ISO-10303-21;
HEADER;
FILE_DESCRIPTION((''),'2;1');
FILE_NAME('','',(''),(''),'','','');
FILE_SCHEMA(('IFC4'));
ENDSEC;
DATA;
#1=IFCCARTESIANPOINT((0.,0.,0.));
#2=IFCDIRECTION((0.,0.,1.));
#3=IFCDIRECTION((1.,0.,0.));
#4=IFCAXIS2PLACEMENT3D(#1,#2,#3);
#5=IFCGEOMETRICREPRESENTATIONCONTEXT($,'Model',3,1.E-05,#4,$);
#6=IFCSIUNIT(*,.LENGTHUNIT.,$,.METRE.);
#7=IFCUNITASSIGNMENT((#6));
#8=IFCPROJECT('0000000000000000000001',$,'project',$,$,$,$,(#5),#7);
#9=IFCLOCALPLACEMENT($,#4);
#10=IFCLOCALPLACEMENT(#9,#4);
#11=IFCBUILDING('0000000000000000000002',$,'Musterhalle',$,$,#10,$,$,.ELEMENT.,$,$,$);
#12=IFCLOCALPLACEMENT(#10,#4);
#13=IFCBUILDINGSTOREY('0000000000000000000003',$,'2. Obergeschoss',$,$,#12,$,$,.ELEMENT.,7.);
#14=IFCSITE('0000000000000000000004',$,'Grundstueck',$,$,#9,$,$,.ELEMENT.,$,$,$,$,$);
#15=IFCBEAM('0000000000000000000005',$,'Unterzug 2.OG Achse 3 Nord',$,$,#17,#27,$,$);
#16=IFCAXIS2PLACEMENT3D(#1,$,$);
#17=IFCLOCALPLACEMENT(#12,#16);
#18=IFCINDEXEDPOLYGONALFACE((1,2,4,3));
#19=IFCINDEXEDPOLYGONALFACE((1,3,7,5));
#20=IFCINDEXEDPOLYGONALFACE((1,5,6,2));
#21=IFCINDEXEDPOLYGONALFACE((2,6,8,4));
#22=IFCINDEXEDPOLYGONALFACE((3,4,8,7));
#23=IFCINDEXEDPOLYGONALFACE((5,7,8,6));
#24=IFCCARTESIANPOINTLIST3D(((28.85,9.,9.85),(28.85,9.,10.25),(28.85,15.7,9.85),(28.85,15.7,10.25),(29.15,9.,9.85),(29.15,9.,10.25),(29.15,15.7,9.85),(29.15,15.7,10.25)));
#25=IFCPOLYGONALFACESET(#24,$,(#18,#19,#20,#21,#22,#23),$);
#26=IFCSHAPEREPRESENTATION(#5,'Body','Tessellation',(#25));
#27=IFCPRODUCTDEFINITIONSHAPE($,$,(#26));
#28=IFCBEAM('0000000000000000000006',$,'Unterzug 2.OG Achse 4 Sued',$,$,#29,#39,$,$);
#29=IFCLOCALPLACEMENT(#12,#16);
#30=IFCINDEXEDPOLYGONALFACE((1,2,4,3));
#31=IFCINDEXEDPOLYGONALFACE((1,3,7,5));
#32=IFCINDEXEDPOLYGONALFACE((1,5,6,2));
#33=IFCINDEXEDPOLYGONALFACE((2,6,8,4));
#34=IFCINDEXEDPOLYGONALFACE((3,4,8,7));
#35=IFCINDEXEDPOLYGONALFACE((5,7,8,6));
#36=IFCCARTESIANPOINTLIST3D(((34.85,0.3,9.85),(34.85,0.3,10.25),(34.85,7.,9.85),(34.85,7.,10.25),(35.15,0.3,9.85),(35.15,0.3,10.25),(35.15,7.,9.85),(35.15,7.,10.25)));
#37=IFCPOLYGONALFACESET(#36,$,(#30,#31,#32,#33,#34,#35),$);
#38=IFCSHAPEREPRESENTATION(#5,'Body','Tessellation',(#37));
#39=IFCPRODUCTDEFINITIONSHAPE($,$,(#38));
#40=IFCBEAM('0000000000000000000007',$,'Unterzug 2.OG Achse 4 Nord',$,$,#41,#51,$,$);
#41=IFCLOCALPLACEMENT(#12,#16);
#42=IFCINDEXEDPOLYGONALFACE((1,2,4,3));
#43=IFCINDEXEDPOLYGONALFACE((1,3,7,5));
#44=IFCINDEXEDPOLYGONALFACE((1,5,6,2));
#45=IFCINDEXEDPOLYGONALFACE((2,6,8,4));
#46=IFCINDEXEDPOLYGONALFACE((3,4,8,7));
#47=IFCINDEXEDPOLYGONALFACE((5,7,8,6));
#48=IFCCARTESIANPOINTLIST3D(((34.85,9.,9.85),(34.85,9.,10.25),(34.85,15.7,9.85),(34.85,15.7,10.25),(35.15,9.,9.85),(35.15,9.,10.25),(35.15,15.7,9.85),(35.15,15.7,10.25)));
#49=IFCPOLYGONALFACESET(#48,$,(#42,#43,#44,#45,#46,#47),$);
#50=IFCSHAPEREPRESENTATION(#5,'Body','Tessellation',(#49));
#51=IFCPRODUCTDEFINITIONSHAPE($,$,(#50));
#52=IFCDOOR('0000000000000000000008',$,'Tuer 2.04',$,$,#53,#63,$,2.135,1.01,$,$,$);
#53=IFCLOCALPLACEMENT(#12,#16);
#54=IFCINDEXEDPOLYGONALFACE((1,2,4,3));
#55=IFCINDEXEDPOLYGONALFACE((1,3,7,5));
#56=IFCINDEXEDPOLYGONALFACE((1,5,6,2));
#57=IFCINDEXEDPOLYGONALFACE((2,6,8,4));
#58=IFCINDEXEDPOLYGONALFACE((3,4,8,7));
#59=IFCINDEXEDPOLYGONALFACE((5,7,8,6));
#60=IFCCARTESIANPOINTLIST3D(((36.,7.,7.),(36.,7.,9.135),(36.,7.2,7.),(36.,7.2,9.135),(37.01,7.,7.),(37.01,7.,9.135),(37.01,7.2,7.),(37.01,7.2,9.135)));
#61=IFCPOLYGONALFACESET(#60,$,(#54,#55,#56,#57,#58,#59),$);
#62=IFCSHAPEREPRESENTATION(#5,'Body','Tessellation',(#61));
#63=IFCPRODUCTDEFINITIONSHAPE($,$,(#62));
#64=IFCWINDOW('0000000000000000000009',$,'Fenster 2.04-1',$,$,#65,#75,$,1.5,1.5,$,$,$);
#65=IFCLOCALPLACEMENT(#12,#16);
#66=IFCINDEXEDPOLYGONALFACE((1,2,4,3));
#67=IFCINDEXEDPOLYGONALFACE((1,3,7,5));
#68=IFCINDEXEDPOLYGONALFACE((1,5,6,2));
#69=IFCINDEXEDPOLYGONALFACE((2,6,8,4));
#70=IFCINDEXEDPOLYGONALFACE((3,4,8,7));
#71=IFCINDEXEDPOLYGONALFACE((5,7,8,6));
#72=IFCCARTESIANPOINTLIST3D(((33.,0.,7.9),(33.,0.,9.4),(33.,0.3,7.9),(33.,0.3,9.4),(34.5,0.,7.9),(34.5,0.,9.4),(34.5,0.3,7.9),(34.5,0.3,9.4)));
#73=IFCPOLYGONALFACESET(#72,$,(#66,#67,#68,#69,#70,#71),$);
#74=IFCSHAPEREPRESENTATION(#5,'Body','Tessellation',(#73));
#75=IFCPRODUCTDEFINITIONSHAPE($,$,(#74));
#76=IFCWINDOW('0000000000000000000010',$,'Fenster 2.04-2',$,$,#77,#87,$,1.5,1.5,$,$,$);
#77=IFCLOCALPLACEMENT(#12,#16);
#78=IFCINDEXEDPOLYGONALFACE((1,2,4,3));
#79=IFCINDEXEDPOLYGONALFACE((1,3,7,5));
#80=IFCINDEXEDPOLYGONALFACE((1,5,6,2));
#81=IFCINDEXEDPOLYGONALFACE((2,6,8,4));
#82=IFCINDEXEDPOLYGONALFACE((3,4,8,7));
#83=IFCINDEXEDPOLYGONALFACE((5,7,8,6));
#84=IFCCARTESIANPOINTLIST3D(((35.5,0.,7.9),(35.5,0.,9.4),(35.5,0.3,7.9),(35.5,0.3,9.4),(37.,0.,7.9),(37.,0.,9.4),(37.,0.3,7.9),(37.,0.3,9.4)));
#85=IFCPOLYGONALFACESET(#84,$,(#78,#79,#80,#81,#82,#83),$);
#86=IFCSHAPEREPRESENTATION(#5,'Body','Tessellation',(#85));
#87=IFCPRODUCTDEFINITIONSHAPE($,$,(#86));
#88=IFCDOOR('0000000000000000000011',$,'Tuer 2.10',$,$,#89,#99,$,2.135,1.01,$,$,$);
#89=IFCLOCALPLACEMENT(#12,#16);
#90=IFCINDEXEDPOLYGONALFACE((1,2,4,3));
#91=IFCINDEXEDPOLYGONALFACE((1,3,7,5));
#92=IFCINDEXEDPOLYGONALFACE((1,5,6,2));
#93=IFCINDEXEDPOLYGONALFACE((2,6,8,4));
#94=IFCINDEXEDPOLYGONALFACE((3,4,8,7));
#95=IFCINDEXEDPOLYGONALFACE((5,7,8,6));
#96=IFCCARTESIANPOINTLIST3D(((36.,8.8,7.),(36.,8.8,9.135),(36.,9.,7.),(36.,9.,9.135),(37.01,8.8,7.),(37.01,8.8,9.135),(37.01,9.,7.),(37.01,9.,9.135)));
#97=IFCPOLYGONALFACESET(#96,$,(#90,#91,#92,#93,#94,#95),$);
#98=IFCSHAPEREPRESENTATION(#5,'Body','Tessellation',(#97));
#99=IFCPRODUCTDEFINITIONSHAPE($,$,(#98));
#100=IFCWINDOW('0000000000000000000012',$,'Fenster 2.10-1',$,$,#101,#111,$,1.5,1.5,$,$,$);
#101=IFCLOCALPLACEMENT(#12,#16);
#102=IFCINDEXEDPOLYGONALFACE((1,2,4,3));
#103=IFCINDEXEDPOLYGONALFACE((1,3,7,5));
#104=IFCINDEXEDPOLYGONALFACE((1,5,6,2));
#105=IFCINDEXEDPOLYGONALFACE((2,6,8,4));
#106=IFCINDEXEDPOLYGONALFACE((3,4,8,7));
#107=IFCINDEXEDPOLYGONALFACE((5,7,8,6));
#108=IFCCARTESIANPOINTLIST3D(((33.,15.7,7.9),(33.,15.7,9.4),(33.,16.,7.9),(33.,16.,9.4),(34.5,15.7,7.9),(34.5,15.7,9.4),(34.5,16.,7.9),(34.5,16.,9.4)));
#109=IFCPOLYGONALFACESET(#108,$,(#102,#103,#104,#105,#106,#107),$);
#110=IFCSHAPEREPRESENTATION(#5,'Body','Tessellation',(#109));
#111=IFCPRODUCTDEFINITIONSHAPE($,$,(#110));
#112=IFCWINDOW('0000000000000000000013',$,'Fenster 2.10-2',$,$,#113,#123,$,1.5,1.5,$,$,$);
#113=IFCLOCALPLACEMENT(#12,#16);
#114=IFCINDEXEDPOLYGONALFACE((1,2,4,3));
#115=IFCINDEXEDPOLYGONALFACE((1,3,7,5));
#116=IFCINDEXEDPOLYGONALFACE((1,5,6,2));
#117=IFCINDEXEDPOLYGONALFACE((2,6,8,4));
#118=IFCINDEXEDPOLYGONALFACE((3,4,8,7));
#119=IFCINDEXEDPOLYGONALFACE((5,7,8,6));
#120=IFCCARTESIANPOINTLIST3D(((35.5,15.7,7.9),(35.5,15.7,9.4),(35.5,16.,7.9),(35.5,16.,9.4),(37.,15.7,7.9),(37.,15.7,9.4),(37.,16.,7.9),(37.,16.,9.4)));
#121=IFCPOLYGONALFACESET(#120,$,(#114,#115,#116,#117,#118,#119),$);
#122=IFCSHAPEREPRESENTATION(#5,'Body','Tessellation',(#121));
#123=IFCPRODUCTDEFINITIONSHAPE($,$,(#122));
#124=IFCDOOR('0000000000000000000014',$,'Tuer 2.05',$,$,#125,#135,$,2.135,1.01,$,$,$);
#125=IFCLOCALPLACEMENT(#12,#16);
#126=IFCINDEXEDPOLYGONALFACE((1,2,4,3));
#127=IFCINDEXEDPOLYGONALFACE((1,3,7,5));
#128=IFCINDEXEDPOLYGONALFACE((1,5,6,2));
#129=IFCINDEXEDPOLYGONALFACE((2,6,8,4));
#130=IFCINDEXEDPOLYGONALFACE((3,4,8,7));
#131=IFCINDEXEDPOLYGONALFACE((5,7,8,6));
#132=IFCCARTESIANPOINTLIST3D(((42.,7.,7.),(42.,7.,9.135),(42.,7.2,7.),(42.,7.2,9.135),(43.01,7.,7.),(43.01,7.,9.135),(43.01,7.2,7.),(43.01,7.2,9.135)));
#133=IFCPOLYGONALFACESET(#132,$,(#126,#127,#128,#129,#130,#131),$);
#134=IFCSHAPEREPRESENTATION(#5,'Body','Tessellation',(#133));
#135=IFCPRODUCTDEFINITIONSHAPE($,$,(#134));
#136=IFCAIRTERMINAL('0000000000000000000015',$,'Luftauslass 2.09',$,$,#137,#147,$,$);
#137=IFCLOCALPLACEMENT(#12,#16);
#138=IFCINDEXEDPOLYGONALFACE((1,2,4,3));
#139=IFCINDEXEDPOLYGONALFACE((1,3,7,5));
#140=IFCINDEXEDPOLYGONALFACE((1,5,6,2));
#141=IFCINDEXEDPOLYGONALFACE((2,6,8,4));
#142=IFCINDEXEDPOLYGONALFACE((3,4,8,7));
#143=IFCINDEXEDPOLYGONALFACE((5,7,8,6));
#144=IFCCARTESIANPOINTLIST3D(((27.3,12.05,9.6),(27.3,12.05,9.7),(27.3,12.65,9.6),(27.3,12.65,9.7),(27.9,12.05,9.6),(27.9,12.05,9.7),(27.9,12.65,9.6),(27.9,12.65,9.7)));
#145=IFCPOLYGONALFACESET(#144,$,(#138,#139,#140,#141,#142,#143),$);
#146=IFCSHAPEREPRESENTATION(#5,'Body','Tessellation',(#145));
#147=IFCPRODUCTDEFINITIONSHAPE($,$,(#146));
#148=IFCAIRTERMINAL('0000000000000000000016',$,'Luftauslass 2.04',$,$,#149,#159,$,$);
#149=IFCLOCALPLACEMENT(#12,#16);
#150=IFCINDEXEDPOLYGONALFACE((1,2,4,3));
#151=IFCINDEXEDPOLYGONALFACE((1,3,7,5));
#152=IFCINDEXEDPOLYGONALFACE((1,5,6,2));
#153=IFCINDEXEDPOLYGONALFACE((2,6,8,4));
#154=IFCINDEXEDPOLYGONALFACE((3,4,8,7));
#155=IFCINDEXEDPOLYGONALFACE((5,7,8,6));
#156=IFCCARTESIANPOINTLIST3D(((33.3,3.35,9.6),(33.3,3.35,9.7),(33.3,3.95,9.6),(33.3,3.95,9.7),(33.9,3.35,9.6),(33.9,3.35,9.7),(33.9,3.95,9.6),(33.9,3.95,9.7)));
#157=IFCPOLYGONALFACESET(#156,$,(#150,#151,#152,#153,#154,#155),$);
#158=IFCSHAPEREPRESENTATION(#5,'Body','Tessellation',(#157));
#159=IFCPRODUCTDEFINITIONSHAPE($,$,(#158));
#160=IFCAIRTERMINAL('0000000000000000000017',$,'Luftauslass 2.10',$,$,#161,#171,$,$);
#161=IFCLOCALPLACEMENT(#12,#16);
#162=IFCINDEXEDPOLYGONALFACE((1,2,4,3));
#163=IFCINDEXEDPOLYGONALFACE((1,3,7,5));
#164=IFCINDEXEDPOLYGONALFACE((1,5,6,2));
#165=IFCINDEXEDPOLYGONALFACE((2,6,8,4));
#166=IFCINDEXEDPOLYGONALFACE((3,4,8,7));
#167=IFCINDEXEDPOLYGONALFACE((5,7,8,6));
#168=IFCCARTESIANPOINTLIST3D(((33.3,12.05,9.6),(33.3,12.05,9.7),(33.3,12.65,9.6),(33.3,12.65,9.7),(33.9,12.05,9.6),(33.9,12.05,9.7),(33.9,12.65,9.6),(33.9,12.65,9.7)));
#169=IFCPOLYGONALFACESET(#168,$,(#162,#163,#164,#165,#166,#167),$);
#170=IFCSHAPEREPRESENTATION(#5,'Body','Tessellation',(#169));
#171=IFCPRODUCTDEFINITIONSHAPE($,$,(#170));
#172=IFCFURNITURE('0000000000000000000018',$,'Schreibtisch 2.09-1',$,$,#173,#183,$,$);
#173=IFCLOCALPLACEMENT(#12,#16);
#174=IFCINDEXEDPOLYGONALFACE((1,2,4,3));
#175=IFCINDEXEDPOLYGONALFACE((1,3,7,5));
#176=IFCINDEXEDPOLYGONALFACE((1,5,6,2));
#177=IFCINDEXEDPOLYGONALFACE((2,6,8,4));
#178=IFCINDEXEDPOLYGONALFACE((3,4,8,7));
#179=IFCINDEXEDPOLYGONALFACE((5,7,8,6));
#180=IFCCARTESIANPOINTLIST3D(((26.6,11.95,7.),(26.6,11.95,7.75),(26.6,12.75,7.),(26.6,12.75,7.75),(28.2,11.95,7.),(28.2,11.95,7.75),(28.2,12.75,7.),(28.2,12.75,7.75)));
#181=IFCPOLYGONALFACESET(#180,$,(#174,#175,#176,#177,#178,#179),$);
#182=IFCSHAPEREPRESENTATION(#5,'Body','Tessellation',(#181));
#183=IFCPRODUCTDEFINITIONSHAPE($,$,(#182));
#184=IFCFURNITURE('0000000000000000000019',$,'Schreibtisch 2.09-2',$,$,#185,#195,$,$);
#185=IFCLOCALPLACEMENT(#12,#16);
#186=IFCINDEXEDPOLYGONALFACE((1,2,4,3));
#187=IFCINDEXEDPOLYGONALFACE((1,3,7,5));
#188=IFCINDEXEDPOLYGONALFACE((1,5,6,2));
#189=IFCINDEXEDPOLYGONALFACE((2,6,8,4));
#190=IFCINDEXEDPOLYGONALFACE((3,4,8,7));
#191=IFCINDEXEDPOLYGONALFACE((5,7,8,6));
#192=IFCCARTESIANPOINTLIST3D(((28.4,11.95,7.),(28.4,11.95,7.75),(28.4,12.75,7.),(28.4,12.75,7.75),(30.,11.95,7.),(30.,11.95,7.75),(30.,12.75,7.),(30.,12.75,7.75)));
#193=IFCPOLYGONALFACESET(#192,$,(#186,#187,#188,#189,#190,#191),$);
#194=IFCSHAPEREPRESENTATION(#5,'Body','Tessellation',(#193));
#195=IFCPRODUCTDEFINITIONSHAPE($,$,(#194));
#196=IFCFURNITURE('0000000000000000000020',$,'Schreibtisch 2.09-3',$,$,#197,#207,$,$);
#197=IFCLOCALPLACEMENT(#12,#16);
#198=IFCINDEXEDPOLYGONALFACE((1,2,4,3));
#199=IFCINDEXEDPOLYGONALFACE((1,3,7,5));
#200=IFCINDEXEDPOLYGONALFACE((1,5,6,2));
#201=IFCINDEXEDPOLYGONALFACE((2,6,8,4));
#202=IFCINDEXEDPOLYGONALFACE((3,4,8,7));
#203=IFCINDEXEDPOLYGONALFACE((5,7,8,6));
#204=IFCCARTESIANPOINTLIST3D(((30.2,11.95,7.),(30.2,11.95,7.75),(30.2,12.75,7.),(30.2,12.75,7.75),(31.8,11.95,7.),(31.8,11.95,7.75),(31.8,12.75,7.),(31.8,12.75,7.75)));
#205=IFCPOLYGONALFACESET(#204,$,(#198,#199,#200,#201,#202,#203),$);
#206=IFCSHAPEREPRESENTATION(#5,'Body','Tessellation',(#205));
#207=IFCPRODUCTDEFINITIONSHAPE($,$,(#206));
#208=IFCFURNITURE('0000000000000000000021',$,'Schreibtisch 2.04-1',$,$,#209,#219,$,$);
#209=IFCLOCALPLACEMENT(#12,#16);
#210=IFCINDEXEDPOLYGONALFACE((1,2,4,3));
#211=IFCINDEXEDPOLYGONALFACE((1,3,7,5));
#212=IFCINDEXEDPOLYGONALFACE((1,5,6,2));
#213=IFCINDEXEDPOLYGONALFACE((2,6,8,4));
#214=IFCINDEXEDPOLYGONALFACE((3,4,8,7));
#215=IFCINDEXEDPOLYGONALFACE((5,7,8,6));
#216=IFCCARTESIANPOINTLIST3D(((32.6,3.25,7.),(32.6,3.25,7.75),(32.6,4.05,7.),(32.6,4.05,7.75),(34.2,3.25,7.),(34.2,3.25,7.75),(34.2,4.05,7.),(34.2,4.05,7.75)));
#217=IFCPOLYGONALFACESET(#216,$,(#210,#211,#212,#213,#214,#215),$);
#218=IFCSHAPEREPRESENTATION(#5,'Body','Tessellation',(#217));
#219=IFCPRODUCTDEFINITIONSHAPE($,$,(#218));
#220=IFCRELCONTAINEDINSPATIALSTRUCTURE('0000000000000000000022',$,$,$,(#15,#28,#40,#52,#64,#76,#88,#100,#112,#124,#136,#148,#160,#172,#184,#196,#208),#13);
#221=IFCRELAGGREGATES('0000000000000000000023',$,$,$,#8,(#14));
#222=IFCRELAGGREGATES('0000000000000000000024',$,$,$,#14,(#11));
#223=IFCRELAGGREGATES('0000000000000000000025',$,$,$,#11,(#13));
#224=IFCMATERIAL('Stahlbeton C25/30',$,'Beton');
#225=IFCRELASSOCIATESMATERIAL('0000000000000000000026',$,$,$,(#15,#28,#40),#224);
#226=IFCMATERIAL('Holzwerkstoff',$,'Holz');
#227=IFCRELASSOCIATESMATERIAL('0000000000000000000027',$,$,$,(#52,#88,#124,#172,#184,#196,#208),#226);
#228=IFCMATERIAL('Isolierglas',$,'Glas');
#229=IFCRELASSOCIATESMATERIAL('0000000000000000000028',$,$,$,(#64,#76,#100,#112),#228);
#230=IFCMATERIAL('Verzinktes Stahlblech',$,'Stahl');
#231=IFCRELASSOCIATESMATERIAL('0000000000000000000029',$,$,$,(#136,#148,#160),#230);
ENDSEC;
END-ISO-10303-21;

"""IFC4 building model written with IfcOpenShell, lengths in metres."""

from ifc_helpers import new_model, si_unit, frame, origin_with_axes, origin_2d, place, context, project, spatial, rectangle, extrude, material, element, save


model = new_model("IFC4")

# Units and contexts
model_context = context("Model", 3, precision=1e-05, world=origin_with_axes())
ifc_project = project(units=[si_unit("LENGTHUNIT", "METRE")], contexts=[model_context])

# Site, building, storey
site_placement = place(None, origin_with_axes())
site = spatial("IfcSite", under=ifc_project, at=site_placement, Name="Grundstueck", CompositionType="ELEMENT")
building_placement = place(site_placement, origin_with_axes())
building = spatial("IfcBuilding", under=site, at=building_placement, Name="Musterhalle", CompositionType="ELEMENT")
storey_placement = place(building_placement, origin_with_axes())
storey = spatial("IfcBuildingStorey", under=building, at=storey_placement, Name="2. Obergeschoss", CompositionType="ELEMENT", Elevation=7.0)

# Beams
ifc_material_1 = material(Name="Stahlbeton C25/30", Category="Beton")
placement = place(storey_placement, origin_with_axes())
element("IfcBeam", 1, at=placement, inside=storey, material=ifc_material_1, Name="Unterzug 2.OG Achse 3 Nord", context=model_context, shape_type="SweptSolid", body=[
    extrude(rectangle(XDim=0.3, YDim=6.7, at=origin_2d()), frame((29.0, 12.35, 9.85), z_axis=(0.0, 0.0, 1.0), x_axis=(1.0, 0.0, 0.0)), (0.0, 0.0, 1.0), 0.4),
])
element("IfcBeam", 2, at=placement, inside=storey, material=ifc_material_1, Name="Unterzug 2.OG Achse 4 Sued", context=model_context, shape_type="SweptSolid", body=[
    extrude(rectangle(XDim=0.3, YDim=6.7, at=origin_2d()), frame((35.0, 3.65, 9.85), z_axis=(0.0, 0.0, 1.0), x_axis=(1.0, 0.0, 0.0)), (0.0, 0.0, 1.0), 0.4),
])
element("IfcBeam", 3, at=placement, inside=storey, material=ifc_material_1, Name="Unterzug 2.OG Achse 4 Nord", context=model_context, shape_type="SweptSolid", body=[
    extrude(rectangle(XDim=0.3, YDim=6.7, at=origin_2d()), frame((35.0, 12.35, 9.85), z_axis=(0.0, 0.0, 1.0), x_axis=(1.0, 0.0, 0.0)), (0.0, 0.0, 1.0), 0.4),
])

# Door
ifc_material_2 = material(Name="Holzwerkstoff", Category="Holz")
element("IfcDoor", 4, at=placement, inside=storey, material=ifc_material_2, Name="Tuer 2.04", OverallHeight=2.135, OverallWidth=1.01, context=model_context, shape_type="SweptSolid", body=[
    extrude(rectangle(XDim=1.01, YDim=0.2, at=origin_2d()), frame((36.505, 7.1, 7.0), z_axis=(0.0, 0.0, 1.0), x_axis=(1.0, 0.0, 0.0)), (0.0, 0.0, 1.0), 2.135),
])

# Windows
ifc_material_3 = material(Name="Isolierglas", Category="Glas")
element("IfcWindow", 5, at=placement, inside=storey, material=ifc_material_3, Name="Fenster 2.04-1", OverallHeight=1.5, OverallWidth=1.5, context=model_context, shape_type="SweptSolid", body=[
    extrude(rectangle(XDim=1.5, YDim=0.3, at=origin_2d()), frame((33.75, 0.15, 7.9), z_axis=(0.0, 0.0, 1.0), x_axis=(1.0, 0.0, 0.0)), (0.0, 0.0, 1.0), 1.5),
])
element("IfcWindow", 6, at=placement, inside=storey, material=ifc_material_3, Name="Fenster 2.04-2", OverallHeight=1.5, OverallWidth=1.5, context=model_context, shape_type="SweptSolid", body=[
    extrude(rectangle(XDim=1.5, YDim=0.3, at=origin_2d()), frame((36.25, 0.15, 7.9), z_axis=(0.0, 0.0, 1.0), x_axis=(1.0, 0.0, 0.0)), (0.0, 0.0, 1.0), 1.5),
])

# Door
element("IfcDoor", 7, at=placement, inside=storey, material=ifc_material_2, Name="Tuer 2.10", OverallHeight=2.135, OverallWidth=1.01, context=model_context, shape_type="SweptSolid", body=[
    extrude(rectangle(XDim=1.01, YDim=0.2, at=origin_2d()), frame((36.505, 8.9, 7.0), z_axis=(0.0, 0.0, 1.0), x_axis=(1.0, 0.0, 0.0)), (0.0, 0.0, 1.0), 2.135),
])

# Windows
element("IfcWindow", 8, at=placement, inside=storey, material=ifc_material_3, Name="Fenster 2.10-1", OverallHeight=1.5, OverallWidth=1.5, context=model_context, shape_type="SweptSolid", body=[
    extrude(rectangle(XDim=1.5, YDim=0.3, at=origin_2d()), frame((33.75, 15.85, 7.9), z_axis=(0.0, 0.0, 1.0), x_axis=(1.0, 0.0, 0.0)), (0.0, 0.0, 1.0), 1.5),
])
element("IfcWindow", 9, at=placement, inside=storey, material=ifc_material_3, Name="Fenster 2.10-2", OverallHeight=1.5, OverallWidth=1.5, context=model_context, shape_type="SweptSolid", body=[
    extrude(rectangle(XDim=1.5, YDim=0.3, at=origin_2d()), frame((36.25, 15.85, 7.9), z_axis=(0.0, 0.0, 1.0), x_axis=(1.0, 0.0, 0.0)), (0.0, 0.0, 1.0), 1.5),
])

# Door
element("IfcDoor", 10, at=placement, inside=storey, material=ifc_material_2, Name="Tuer 2.05", OverallHeight=2.135, OverallWidth=1.01, context=model_context, shape_type="SweptSolid", body=[
    extrude(rectangle(XDim=1.01, YDim=0.2, at=origin_2d()), frame((42.505, 7.1, 7.0), z_axis=(0.0, 0.0, 1.0), x_axis=(1.0, 0.0, 0.0)), (0.0, 0.0, 1.0), 2.135),
])

# Air terminals
ifc_material_4 = material(Name="Verzinktes Stahlblech", Category="Stahl")
element("IfcAirTerminal", 11, at=placement, inside=storey, material=ifc_material_4, Name="Luftauslass 2.09", context=model_context, shape_type="SweptSolid", body=[
    extrude(rectangle(XDim=0.6, YDim=0.6, at=origin_2d()), frame((27.6, 12.35, 9.6), z_axis=(0.0, 0.0, 1.0), x_axis=(1.0, 0.0, 0.0)), (0.0, 0.0, 1.0), 0.1),
])
element("IfcAirTerminal", 12, at=placement, inside=storey, material=ifc_material_4, Name="Luftauslass 2.04", context=model_context, shape_type="SweptSolid", body=[
    extrude(rectangle(XDim=0.6, YDim=0.6, at=origin_2d()), frame((33.6, 3.65, 9.6), z_axis=(0.0, 0.0, 1.0), x_axis=(1.0, 0.0, 0.0)), (0.0, 0.0, 1.0), 0.1),
])
element("IfcAirTerminal", 13, at=placement, inside=storey, material=ifc_material_4, Name="Luftauslass 2.10", context=model_context, shape_type="SweptSolid", body=[
    extrude(rectangle(XDim=0.6, YDim=0.6, at=origin_2d()), frame((33.6, 12.35, 9.6), z_axis=(0.0, 0.0, 1.0), x_axis=(1.0, 0.0, 0.0)), (0.0, 0.0, 1.0), 0.1),
])

# Furniture
element("IfcFurniture", 14, at=placement, inside=storey, material=ifc_material_2, Name="Schreibtisch 2.09-1", context=model_context, shape_type="SweptSolid", body=[
    extrude(rectangle(XDim=1.6, YDim=0.8, at=origin_2d()), frame((27.4, 12.35, 7.0), z_axis=(0.0, 0.0, 1.0), x_axis=(1.0, 0.0, 0.0)), (0.0, 0.0, 1.0), 0.75),
])
element("IfcFurniture", 15, at=placement, inside=storey, material=ifc_material_2, Name="Schreibtisch 2.09-2", context=model_context, shape_type="SweptSolid", body=[
    extrude(rectangle(XDim=1.6, YDim=0.8, at=origin_2d()), frame((29.2, 12.35, 7.0), z_axis=(0.0, 0.0, 1.0), x_axis=(1.0, 0.0, 0.0)), (0.0, 0.0, 1.0), 0.75),
])
element("IfcFurniture", 16, at=placement, inside=storey, material=ifc_material_2, Name="Schreibtisch 2.09-3", context=model_context, shape_type="SweptSolid", body=[
    extrude(rectangle(XDim=1.6, YDim=0.8, at=origin_2d()), frame((31.0, 12.35, 7.0), z_axis=(0.0, 0.0, 1.0), x_axis=(1.0, 0.0, 0.0)), (0.0, 0.0, 1.0), 0.75),
])
element("IfcFurniture", 17, at=placement, inside=storey, material=ifc_material_2, Name="Schreibtisch 2.04-1", context=model_context, shape_type="SweptSolid", body=[
    extrude(rectangle(XDim=1.6, YDim=0.8, at=origin_2d()), frame((33.4, 3.65, 7.0), z_axis=(0.0, 0.0, 1.0), x_axis=(1.0, 0.0, 0.0)), (0.0, 0.0, 1.0), 0.75),
])

save(model, "model.ifc")
